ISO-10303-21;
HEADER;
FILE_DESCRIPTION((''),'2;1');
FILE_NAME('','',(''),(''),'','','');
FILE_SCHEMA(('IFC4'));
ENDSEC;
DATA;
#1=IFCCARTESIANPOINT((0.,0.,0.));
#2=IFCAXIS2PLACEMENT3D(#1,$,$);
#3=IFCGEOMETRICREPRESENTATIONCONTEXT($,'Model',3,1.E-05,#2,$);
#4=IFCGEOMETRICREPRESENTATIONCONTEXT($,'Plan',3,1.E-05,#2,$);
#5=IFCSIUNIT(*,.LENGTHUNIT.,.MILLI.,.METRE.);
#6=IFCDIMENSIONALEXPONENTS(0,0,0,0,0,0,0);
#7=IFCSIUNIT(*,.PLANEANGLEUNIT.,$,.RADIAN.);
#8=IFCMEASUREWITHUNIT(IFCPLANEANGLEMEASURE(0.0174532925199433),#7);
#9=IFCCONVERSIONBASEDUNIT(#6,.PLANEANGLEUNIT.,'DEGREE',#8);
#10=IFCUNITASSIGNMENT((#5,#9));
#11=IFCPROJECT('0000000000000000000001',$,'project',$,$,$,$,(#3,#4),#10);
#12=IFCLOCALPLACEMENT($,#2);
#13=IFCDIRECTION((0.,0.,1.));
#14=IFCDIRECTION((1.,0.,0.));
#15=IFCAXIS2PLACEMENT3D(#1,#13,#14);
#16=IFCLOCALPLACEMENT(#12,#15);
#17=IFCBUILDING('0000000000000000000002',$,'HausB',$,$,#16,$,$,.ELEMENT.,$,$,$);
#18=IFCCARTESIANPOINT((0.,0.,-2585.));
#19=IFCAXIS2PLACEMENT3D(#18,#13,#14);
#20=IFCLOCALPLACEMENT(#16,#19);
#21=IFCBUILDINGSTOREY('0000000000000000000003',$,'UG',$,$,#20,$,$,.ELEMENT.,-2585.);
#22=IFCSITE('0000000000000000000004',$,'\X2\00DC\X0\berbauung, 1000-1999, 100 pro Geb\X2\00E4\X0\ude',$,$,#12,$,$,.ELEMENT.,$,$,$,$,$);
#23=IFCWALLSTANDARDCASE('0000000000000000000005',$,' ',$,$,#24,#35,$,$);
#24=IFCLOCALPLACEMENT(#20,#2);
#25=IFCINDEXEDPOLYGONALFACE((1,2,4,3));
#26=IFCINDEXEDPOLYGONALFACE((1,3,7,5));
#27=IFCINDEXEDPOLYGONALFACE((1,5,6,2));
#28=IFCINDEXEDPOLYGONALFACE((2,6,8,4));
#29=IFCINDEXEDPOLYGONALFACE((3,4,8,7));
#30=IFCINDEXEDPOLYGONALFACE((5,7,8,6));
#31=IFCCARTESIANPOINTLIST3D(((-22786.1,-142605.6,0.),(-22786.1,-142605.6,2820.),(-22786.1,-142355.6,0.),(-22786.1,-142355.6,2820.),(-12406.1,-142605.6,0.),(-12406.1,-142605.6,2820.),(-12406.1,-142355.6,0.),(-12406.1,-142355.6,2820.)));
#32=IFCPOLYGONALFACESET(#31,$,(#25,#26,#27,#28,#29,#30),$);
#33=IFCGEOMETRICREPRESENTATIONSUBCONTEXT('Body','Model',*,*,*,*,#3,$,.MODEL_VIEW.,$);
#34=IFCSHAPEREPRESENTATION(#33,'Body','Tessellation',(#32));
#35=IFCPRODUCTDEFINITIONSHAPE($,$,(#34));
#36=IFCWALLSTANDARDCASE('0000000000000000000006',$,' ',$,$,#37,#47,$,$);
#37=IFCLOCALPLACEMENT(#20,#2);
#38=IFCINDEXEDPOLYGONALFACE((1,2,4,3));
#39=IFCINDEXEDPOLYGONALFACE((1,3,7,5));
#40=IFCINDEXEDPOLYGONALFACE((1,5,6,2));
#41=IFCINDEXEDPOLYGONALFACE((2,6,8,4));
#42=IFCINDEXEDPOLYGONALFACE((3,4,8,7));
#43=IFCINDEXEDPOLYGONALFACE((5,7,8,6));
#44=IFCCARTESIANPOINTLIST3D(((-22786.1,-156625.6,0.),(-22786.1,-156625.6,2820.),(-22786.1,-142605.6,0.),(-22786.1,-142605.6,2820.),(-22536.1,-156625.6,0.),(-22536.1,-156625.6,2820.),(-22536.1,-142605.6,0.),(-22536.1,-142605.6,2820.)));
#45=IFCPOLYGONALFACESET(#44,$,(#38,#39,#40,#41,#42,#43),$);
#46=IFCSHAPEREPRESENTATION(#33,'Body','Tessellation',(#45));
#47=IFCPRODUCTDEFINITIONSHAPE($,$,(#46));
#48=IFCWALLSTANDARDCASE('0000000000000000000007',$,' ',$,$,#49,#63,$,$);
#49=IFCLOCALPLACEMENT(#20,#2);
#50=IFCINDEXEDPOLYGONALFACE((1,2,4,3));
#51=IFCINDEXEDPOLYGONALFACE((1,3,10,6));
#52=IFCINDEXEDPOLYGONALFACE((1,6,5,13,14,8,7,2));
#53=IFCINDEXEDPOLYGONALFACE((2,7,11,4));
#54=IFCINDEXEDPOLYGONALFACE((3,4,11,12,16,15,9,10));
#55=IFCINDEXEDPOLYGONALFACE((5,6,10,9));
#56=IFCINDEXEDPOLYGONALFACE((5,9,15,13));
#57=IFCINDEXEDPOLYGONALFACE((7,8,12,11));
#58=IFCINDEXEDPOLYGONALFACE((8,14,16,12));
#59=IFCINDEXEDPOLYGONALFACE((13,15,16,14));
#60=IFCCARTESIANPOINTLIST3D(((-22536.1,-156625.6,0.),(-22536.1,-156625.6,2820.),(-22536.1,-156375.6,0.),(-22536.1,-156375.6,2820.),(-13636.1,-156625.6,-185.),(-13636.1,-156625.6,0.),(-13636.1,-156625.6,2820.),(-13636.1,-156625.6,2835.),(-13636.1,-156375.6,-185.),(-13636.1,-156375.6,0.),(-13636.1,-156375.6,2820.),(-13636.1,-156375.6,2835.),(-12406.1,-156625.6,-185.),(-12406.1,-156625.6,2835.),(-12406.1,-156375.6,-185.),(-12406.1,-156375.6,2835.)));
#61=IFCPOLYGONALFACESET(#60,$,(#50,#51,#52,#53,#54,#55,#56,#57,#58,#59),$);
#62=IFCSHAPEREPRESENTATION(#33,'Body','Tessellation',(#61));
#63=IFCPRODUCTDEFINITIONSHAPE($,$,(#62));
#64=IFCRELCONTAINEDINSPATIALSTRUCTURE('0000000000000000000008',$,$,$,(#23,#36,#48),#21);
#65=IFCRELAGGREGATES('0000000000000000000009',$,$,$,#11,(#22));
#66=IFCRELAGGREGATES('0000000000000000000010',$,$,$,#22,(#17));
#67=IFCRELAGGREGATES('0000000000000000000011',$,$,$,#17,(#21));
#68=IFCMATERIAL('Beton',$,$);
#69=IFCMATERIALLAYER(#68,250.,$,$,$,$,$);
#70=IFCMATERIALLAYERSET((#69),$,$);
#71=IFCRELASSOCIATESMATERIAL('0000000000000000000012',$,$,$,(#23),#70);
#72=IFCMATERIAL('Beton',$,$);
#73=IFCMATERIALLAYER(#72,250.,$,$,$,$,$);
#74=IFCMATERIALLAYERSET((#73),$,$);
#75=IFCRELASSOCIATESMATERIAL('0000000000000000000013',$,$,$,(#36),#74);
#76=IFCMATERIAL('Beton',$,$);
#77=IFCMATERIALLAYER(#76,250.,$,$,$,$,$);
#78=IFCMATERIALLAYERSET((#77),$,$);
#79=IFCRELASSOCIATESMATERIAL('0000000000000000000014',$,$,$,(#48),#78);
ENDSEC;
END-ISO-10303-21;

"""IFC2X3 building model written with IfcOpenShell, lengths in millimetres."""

from ifc_helpers import new_model, entity, si_unit, converted_unit, frame, frame_2d, origin, origin_with_axes, place, context, subcontext, project, spatial, polyline, rectangle, extrude, clip, bounded_halfspace, material, layer, layer_set, layer_usage, element, save


model = new_model("IFC2X3")

# Units and contexts
model_context = context("Model", 3, precision=1e-05, world=origin())
plan_context = context("Plan", 3, precision=1e-05, world=origin())
body_context = subcontext(model_context, "Body", "Model", "MODEL_VIEW")
ifc_project = project(units=[si_unit("LENGTHUNIT", "METRE", prefix="MILLI"), converted_unit("PLANEANGLEUNIT", "DEGREE", entity("IfcPlaneAngleMeasure", 0.0174532925199433), si_unit("PLANEANGLEUNIT", "RADIAN"), dimensions=[0, 0, 0, 0, 0, 0, 0])], contexts=[model_context, plan_context])

# Site, building, storey
site_placement = place(None, origin())
site = spatial("IfcSite", under=ifc_project, at=site_placement, Name="Überbauung, 1000-1999, 100 pro Gebäude", CompositionType="ELEMENT")
building_placement = place(site_placement, origin_with_axes())
building = spatial("IfcBuilding", under=site, at=building_placement, Name="HausB", CompositionType="ELEMENT")
storey_placement = place(building_placement, frame((0.0, 0.0, -2585.0), z_axis=(0.0, 0.0, 1.0), x_axis=(1.0, 0.0, 0.0)))
storey = spatial("IfcBuildingStorey", under=building, at=storey_placement, Name="UG", CompositionType="ELEMENT", Elevation=-2585.0)

# Walls
ifc_material_1 = material(Name="Beton")
ifc_layer_1 = layer(ifc_material_1, 250.0)
ifc_layer_set_1 = layer_set([ifc_layer_1])
ifc_layer_usage_1 = layer_usage(ifc_layer_set_1, "AXIS2", "POSITIVE", 0.0)
wall_1_placement = place(storey_placement, frame((-12406.1, -142355.6, 0.0), z_axis=(0.0, 0.0, 1.0), x_axis=(-1.0, 0.0, 0.0)))
element("IfcWallStandardCase", 1, at=wall_1_placement, inside=storey, material=ifc_layer_usage_1, Name=" ", context=body_context, shape_type="SweptSolid", body=[
    extrude(rectangle(XDim=10380.0, YDim=250.0, at=frame_2d((5190.0, 125.0), x_axis=(1.0, 0.0))), origin_with_axes(), (0.0, 0.0, 1.0), 2820.0),
])
ifc_material_2 = material(Name="Beton")
ifc_layer_2 = layer(ifc_material_2, 250.0)
ifc_layer_set_2 = layer_set([ifc_layer_2])
ifc_layer_usage_2 = layer_usage(ifc_layer_set_2, "AXIS2", "POSITIVE", 0.0)
wall_2_placement = place(storey_placement, frame((-22786.1, -142605.6, 0.0), z_axis=(0.0, 0.0, 1.0), x_axis=(0.0, -1.0, 0.0)))
element("IfcWallStandardCase", 2, at=wall_2_placement, inside=storey, material=ifc_layer_usage_2, Name=" ", context=body_context, shape_type="SweptSolid", body=[
    extrude(rectangle(XDim=14020.0, YDim=250.0, at=frame_2d((7010.0, 125.0), x_axis=(1.0, 0.0))), origin_with_axes(), (0.0, 0.0, 1.0), 2820.0),
])
ifc_material_3 = material(Name="Beton")
ifc_layer_3 = layer(ifc_material_3, 250.0)
ifc_layer_set_3 = layer_set([ifc_layer_3])
ifc_layer_usage_3 = layer_usage(ifc_layer_set_3, "AXIS2", "POSITIVE", 0.0)
wall_3_placement = place(storey_placement, frame((-22536.1, -156625.6, -185.0), z_axis=(0.0, 0.0, 1.0), x_axis=(1.0, 0.0, 0.0)))
element("IfcWallStandardCase", 3, at=wall_3_placement, inside=storey, material=ifc_layer_usage_3, Name=" ", context=body_context, shape_type="Clipping", body=[
    clip(clip(clip(clip(extrude(rectangle(XDim=10130.0, YDim=250.0, at=frame_2d((5065.0, 125.0), x_axis=(1.0, 0.0))), origin_with_axes(), (0.0, 0.0, 1.0), 3020.0), bounded_halfspace(frame((8900.0, 250.0, 0.0), z_axis=(0.0, 0.0, 1.0), x_axis=(0.0, -1.0, 0.0)), True, origin(), polyline([(8900.0, 250.0), (8900.0, 0.0), (10130.0, 0.0), (10130.0, 250.0), (8900.0, 250.0)]))), bounded_halfspace(frame((8900.0, 0.0, 3020.0), z_axis=(0.0, 0.0, -1.0), x_axis=(1.0, 0.0, 0.0)), True, origin(), polyline([(8900.0, 0.0), (10130.0, 0.0), (10130.0, 250.0), (8900.0, 250.0), (8900.0, 0.0)]))), bounded_halfspace(frame((0.0, 0.0, 185.0), z_axis=(0.0, 0.0, 1.0), x_axis=(1.0, 0.0, 0.0)), True, origin(), polyline([(0.0, 0.0), (8900.0, 0.0), (8900.0, 250.0), (0.0, 250.0), (0.0, 0.0)]))), bounded_halfspace(frame((8900.0, 0.0, 3005.0), z_axis=(0.0, 0.0, -1.0), x_axis=(0.0, 1.0, 0.0)), True, origin(), polyline([(8900.0, 0.0), (8900.0, 250.0), (0.0, 250.0), (0.0, 0.0), (8900.0, 0.0)]))),
])

save(model, "model.ifc")
